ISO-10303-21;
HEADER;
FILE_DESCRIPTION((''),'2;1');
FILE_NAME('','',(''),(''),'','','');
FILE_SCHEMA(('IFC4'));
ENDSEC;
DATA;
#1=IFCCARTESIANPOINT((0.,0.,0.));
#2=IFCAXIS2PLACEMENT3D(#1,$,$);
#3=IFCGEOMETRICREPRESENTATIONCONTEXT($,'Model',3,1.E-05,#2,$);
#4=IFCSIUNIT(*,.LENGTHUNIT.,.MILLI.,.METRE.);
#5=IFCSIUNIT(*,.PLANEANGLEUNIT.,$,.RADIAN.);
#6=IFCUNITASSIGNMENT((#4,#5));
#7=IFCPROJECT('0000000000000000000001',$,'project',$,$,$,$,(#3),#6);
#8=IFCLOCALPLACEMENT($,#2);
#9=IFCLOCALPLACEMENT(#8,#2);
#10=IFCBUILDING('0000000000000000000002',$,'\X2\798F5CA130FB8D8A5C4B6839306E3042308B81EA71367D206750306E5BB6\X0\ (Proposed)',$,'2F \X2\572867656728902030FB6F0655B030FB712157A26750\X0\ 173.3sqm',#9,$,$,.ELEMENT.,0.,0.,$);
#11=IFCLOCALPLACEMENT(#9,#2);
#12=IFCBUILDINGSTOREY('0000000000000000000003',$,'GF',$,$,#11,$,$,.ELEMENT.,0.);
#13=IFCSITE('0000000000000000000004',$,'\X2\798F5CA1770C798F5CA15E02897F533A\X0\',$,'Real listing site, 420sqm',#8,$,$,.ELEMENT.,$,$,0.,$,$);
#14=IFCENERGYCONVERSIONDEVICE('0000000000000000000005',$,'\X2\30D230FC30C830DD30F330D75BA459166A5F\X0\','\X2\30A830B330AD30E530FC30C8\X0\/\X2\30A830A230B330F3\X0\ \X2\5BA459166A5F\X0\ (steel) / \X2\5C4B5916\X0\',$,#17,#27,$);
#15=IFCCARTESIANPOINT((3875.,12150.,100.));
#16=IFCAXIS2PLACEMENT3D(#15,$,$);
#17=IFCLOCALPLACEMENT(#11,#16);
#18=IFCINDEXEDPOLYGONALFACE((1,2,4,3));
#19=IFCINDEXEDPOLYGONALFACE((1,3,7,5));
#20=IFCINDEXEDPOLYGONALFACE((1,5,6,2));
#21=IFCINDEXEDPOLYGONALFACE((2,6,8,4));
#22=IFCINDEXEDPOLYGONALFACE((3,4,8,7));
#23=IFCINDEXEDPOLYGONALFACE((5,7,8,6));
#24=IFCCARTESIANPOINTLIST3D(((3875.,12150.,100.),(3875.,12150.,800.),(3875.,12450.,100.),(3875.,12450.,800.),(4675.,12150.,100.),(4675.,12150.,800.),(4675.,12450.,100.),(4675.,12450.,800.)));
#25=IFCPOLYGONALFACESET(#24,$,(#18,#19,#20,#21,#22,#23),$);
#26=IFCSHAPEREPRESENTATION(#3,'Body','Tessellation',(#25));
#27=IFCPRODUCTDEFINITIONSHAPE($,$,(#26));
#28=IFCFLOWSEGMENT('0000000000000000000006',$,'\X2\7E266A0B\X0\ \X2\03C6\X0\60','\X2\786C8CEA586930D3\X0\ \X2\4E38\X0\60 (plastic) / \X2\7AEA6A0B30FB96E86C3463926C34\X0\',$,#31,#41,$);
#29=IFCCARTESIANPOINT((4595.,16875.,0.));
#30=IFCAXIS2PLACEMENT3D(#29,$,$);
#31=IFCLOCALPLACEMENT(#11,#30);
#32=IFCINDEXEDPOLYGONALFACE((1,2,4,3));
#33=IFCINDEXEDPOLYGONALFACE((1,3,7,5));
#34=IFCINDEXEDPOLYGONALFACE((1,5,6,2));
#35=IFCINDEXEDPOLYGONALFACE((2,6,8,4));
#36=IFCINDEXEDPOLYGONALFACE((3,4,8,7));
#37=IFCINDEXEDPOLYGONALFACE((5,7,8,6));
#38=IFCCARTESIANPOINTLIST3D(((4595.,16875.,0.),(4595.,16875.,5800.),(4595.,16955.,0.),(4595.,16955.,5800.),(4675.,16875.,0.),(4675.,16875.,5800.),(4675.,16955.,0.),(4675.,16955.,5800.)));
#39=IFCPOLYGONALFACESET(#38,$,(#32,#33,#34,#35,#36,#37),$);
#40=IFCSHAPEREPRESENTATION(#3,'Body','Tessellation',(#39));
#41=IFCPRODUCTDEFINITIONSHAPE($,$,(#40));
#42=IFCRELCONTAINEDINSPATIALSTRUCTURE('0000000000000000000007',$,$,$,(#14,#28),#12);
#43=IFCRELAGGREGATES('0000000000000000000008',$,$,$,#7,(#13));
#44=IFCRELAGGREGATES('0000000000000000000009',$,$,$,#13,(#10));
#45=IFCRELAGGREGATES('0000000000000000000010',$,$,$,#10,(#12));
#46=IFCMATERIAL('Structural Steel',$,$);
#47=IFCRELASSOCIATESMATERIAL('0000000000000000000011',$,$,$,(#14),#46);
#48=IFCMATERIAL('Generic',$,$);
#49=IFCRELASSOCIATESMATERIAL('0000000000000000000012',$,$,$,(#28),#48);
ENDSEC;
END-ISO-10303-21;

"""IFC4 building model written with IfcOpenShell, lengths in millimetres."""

from ifc_helpers import new_model, si_unit, frame, frame_2d, origin, place, context, project, spatial, rectangle, extrude, material, element, save


model = new_model("IFC4")

# Units and contexts
model_context = context("Model", 3, precision=1e-05, world=origin())
ifc_project = project(units=[si_unit("LENGTHUNIT", "METRE", prefix="MILLI"), si_unit("PLANEANGLEUNIT", "RADIAN")], contexts=[model_context])

# Site, building, storey
site_placement = place(None, origin())
site = spatial("IfcSite", under=ifc_project, at=site_placement, Name="福岡県福岡市西区", ObjectType="Real listing site, 420sqm", CompositionType="ELEMENT", RefElevation=0.0)
building_placement = place(site_placement, origin())
building = spatial("IfcBuilding", under=site, at=building_placement, Name="福岡・越屋根のある自然素材の家 (Proposed)", ObjectType="2F 在来木造・漆喰・無垢材 173.3sqm", CompositionType="ELEMENT", ElevationOfRefHeight=0.0, ElevationOfTerrain=0.0)
storey_placement = place(building_placement, origin())
storey = spatial("IfcBuildingStorey", under=building, at=storey_placement, Name="GF", CompositionType="ELEMENT", Elevation=0.0)

# Shared definitions
ifc_material_1 = material(Name="Generic")

# Energy conversion device
ifc_material_2 = material(Name="Structural Steel")
energy_conversion_device_placement = place(storey_placement, frame((3875.0, 12150.0, 100.0)))
element("IfcEnergyConversionDevice", 1, at=energy_conversion_device_placement, inside=storey, material=ifc_material_2, Name="ヒートポンプ室外機", Description="エコキュート/エアコン 室外機 (steel) / 屋外", context=model_context, shape_type="SweptSolid", body=[
    extrude(rectangle(XDim=800.0, YDim=300.0, at=frame_2d((400.0, 150.0))), frame((3875.0, 12150.0, 100.0)), (0.0, 0.0, 1.0), 700.0),
])

# Flow segment
flow_segment_placement = place(storey_placement, frame((4595.0, 16875.0, 0.0)))
element("IfcFlowSegment", 2, at=flow_segment_placement, inside=storey, material=ifc_material_1, Name="縦樋 φ60", Description="硬質塩ビ 丸60 (plastic) / 竪樋・雨水排水", context=model_context, shape_type="SweptSolid", body=[
    extrude(rectangle(XDim=80.0, YDim=80.0, at=frame_2d((40.0, 40.0))), frame((4595.0, 16875.0, 0.0)), (0.0, 0.0, 1.0), 5800.0),
])

save(model, "model.ifc")
